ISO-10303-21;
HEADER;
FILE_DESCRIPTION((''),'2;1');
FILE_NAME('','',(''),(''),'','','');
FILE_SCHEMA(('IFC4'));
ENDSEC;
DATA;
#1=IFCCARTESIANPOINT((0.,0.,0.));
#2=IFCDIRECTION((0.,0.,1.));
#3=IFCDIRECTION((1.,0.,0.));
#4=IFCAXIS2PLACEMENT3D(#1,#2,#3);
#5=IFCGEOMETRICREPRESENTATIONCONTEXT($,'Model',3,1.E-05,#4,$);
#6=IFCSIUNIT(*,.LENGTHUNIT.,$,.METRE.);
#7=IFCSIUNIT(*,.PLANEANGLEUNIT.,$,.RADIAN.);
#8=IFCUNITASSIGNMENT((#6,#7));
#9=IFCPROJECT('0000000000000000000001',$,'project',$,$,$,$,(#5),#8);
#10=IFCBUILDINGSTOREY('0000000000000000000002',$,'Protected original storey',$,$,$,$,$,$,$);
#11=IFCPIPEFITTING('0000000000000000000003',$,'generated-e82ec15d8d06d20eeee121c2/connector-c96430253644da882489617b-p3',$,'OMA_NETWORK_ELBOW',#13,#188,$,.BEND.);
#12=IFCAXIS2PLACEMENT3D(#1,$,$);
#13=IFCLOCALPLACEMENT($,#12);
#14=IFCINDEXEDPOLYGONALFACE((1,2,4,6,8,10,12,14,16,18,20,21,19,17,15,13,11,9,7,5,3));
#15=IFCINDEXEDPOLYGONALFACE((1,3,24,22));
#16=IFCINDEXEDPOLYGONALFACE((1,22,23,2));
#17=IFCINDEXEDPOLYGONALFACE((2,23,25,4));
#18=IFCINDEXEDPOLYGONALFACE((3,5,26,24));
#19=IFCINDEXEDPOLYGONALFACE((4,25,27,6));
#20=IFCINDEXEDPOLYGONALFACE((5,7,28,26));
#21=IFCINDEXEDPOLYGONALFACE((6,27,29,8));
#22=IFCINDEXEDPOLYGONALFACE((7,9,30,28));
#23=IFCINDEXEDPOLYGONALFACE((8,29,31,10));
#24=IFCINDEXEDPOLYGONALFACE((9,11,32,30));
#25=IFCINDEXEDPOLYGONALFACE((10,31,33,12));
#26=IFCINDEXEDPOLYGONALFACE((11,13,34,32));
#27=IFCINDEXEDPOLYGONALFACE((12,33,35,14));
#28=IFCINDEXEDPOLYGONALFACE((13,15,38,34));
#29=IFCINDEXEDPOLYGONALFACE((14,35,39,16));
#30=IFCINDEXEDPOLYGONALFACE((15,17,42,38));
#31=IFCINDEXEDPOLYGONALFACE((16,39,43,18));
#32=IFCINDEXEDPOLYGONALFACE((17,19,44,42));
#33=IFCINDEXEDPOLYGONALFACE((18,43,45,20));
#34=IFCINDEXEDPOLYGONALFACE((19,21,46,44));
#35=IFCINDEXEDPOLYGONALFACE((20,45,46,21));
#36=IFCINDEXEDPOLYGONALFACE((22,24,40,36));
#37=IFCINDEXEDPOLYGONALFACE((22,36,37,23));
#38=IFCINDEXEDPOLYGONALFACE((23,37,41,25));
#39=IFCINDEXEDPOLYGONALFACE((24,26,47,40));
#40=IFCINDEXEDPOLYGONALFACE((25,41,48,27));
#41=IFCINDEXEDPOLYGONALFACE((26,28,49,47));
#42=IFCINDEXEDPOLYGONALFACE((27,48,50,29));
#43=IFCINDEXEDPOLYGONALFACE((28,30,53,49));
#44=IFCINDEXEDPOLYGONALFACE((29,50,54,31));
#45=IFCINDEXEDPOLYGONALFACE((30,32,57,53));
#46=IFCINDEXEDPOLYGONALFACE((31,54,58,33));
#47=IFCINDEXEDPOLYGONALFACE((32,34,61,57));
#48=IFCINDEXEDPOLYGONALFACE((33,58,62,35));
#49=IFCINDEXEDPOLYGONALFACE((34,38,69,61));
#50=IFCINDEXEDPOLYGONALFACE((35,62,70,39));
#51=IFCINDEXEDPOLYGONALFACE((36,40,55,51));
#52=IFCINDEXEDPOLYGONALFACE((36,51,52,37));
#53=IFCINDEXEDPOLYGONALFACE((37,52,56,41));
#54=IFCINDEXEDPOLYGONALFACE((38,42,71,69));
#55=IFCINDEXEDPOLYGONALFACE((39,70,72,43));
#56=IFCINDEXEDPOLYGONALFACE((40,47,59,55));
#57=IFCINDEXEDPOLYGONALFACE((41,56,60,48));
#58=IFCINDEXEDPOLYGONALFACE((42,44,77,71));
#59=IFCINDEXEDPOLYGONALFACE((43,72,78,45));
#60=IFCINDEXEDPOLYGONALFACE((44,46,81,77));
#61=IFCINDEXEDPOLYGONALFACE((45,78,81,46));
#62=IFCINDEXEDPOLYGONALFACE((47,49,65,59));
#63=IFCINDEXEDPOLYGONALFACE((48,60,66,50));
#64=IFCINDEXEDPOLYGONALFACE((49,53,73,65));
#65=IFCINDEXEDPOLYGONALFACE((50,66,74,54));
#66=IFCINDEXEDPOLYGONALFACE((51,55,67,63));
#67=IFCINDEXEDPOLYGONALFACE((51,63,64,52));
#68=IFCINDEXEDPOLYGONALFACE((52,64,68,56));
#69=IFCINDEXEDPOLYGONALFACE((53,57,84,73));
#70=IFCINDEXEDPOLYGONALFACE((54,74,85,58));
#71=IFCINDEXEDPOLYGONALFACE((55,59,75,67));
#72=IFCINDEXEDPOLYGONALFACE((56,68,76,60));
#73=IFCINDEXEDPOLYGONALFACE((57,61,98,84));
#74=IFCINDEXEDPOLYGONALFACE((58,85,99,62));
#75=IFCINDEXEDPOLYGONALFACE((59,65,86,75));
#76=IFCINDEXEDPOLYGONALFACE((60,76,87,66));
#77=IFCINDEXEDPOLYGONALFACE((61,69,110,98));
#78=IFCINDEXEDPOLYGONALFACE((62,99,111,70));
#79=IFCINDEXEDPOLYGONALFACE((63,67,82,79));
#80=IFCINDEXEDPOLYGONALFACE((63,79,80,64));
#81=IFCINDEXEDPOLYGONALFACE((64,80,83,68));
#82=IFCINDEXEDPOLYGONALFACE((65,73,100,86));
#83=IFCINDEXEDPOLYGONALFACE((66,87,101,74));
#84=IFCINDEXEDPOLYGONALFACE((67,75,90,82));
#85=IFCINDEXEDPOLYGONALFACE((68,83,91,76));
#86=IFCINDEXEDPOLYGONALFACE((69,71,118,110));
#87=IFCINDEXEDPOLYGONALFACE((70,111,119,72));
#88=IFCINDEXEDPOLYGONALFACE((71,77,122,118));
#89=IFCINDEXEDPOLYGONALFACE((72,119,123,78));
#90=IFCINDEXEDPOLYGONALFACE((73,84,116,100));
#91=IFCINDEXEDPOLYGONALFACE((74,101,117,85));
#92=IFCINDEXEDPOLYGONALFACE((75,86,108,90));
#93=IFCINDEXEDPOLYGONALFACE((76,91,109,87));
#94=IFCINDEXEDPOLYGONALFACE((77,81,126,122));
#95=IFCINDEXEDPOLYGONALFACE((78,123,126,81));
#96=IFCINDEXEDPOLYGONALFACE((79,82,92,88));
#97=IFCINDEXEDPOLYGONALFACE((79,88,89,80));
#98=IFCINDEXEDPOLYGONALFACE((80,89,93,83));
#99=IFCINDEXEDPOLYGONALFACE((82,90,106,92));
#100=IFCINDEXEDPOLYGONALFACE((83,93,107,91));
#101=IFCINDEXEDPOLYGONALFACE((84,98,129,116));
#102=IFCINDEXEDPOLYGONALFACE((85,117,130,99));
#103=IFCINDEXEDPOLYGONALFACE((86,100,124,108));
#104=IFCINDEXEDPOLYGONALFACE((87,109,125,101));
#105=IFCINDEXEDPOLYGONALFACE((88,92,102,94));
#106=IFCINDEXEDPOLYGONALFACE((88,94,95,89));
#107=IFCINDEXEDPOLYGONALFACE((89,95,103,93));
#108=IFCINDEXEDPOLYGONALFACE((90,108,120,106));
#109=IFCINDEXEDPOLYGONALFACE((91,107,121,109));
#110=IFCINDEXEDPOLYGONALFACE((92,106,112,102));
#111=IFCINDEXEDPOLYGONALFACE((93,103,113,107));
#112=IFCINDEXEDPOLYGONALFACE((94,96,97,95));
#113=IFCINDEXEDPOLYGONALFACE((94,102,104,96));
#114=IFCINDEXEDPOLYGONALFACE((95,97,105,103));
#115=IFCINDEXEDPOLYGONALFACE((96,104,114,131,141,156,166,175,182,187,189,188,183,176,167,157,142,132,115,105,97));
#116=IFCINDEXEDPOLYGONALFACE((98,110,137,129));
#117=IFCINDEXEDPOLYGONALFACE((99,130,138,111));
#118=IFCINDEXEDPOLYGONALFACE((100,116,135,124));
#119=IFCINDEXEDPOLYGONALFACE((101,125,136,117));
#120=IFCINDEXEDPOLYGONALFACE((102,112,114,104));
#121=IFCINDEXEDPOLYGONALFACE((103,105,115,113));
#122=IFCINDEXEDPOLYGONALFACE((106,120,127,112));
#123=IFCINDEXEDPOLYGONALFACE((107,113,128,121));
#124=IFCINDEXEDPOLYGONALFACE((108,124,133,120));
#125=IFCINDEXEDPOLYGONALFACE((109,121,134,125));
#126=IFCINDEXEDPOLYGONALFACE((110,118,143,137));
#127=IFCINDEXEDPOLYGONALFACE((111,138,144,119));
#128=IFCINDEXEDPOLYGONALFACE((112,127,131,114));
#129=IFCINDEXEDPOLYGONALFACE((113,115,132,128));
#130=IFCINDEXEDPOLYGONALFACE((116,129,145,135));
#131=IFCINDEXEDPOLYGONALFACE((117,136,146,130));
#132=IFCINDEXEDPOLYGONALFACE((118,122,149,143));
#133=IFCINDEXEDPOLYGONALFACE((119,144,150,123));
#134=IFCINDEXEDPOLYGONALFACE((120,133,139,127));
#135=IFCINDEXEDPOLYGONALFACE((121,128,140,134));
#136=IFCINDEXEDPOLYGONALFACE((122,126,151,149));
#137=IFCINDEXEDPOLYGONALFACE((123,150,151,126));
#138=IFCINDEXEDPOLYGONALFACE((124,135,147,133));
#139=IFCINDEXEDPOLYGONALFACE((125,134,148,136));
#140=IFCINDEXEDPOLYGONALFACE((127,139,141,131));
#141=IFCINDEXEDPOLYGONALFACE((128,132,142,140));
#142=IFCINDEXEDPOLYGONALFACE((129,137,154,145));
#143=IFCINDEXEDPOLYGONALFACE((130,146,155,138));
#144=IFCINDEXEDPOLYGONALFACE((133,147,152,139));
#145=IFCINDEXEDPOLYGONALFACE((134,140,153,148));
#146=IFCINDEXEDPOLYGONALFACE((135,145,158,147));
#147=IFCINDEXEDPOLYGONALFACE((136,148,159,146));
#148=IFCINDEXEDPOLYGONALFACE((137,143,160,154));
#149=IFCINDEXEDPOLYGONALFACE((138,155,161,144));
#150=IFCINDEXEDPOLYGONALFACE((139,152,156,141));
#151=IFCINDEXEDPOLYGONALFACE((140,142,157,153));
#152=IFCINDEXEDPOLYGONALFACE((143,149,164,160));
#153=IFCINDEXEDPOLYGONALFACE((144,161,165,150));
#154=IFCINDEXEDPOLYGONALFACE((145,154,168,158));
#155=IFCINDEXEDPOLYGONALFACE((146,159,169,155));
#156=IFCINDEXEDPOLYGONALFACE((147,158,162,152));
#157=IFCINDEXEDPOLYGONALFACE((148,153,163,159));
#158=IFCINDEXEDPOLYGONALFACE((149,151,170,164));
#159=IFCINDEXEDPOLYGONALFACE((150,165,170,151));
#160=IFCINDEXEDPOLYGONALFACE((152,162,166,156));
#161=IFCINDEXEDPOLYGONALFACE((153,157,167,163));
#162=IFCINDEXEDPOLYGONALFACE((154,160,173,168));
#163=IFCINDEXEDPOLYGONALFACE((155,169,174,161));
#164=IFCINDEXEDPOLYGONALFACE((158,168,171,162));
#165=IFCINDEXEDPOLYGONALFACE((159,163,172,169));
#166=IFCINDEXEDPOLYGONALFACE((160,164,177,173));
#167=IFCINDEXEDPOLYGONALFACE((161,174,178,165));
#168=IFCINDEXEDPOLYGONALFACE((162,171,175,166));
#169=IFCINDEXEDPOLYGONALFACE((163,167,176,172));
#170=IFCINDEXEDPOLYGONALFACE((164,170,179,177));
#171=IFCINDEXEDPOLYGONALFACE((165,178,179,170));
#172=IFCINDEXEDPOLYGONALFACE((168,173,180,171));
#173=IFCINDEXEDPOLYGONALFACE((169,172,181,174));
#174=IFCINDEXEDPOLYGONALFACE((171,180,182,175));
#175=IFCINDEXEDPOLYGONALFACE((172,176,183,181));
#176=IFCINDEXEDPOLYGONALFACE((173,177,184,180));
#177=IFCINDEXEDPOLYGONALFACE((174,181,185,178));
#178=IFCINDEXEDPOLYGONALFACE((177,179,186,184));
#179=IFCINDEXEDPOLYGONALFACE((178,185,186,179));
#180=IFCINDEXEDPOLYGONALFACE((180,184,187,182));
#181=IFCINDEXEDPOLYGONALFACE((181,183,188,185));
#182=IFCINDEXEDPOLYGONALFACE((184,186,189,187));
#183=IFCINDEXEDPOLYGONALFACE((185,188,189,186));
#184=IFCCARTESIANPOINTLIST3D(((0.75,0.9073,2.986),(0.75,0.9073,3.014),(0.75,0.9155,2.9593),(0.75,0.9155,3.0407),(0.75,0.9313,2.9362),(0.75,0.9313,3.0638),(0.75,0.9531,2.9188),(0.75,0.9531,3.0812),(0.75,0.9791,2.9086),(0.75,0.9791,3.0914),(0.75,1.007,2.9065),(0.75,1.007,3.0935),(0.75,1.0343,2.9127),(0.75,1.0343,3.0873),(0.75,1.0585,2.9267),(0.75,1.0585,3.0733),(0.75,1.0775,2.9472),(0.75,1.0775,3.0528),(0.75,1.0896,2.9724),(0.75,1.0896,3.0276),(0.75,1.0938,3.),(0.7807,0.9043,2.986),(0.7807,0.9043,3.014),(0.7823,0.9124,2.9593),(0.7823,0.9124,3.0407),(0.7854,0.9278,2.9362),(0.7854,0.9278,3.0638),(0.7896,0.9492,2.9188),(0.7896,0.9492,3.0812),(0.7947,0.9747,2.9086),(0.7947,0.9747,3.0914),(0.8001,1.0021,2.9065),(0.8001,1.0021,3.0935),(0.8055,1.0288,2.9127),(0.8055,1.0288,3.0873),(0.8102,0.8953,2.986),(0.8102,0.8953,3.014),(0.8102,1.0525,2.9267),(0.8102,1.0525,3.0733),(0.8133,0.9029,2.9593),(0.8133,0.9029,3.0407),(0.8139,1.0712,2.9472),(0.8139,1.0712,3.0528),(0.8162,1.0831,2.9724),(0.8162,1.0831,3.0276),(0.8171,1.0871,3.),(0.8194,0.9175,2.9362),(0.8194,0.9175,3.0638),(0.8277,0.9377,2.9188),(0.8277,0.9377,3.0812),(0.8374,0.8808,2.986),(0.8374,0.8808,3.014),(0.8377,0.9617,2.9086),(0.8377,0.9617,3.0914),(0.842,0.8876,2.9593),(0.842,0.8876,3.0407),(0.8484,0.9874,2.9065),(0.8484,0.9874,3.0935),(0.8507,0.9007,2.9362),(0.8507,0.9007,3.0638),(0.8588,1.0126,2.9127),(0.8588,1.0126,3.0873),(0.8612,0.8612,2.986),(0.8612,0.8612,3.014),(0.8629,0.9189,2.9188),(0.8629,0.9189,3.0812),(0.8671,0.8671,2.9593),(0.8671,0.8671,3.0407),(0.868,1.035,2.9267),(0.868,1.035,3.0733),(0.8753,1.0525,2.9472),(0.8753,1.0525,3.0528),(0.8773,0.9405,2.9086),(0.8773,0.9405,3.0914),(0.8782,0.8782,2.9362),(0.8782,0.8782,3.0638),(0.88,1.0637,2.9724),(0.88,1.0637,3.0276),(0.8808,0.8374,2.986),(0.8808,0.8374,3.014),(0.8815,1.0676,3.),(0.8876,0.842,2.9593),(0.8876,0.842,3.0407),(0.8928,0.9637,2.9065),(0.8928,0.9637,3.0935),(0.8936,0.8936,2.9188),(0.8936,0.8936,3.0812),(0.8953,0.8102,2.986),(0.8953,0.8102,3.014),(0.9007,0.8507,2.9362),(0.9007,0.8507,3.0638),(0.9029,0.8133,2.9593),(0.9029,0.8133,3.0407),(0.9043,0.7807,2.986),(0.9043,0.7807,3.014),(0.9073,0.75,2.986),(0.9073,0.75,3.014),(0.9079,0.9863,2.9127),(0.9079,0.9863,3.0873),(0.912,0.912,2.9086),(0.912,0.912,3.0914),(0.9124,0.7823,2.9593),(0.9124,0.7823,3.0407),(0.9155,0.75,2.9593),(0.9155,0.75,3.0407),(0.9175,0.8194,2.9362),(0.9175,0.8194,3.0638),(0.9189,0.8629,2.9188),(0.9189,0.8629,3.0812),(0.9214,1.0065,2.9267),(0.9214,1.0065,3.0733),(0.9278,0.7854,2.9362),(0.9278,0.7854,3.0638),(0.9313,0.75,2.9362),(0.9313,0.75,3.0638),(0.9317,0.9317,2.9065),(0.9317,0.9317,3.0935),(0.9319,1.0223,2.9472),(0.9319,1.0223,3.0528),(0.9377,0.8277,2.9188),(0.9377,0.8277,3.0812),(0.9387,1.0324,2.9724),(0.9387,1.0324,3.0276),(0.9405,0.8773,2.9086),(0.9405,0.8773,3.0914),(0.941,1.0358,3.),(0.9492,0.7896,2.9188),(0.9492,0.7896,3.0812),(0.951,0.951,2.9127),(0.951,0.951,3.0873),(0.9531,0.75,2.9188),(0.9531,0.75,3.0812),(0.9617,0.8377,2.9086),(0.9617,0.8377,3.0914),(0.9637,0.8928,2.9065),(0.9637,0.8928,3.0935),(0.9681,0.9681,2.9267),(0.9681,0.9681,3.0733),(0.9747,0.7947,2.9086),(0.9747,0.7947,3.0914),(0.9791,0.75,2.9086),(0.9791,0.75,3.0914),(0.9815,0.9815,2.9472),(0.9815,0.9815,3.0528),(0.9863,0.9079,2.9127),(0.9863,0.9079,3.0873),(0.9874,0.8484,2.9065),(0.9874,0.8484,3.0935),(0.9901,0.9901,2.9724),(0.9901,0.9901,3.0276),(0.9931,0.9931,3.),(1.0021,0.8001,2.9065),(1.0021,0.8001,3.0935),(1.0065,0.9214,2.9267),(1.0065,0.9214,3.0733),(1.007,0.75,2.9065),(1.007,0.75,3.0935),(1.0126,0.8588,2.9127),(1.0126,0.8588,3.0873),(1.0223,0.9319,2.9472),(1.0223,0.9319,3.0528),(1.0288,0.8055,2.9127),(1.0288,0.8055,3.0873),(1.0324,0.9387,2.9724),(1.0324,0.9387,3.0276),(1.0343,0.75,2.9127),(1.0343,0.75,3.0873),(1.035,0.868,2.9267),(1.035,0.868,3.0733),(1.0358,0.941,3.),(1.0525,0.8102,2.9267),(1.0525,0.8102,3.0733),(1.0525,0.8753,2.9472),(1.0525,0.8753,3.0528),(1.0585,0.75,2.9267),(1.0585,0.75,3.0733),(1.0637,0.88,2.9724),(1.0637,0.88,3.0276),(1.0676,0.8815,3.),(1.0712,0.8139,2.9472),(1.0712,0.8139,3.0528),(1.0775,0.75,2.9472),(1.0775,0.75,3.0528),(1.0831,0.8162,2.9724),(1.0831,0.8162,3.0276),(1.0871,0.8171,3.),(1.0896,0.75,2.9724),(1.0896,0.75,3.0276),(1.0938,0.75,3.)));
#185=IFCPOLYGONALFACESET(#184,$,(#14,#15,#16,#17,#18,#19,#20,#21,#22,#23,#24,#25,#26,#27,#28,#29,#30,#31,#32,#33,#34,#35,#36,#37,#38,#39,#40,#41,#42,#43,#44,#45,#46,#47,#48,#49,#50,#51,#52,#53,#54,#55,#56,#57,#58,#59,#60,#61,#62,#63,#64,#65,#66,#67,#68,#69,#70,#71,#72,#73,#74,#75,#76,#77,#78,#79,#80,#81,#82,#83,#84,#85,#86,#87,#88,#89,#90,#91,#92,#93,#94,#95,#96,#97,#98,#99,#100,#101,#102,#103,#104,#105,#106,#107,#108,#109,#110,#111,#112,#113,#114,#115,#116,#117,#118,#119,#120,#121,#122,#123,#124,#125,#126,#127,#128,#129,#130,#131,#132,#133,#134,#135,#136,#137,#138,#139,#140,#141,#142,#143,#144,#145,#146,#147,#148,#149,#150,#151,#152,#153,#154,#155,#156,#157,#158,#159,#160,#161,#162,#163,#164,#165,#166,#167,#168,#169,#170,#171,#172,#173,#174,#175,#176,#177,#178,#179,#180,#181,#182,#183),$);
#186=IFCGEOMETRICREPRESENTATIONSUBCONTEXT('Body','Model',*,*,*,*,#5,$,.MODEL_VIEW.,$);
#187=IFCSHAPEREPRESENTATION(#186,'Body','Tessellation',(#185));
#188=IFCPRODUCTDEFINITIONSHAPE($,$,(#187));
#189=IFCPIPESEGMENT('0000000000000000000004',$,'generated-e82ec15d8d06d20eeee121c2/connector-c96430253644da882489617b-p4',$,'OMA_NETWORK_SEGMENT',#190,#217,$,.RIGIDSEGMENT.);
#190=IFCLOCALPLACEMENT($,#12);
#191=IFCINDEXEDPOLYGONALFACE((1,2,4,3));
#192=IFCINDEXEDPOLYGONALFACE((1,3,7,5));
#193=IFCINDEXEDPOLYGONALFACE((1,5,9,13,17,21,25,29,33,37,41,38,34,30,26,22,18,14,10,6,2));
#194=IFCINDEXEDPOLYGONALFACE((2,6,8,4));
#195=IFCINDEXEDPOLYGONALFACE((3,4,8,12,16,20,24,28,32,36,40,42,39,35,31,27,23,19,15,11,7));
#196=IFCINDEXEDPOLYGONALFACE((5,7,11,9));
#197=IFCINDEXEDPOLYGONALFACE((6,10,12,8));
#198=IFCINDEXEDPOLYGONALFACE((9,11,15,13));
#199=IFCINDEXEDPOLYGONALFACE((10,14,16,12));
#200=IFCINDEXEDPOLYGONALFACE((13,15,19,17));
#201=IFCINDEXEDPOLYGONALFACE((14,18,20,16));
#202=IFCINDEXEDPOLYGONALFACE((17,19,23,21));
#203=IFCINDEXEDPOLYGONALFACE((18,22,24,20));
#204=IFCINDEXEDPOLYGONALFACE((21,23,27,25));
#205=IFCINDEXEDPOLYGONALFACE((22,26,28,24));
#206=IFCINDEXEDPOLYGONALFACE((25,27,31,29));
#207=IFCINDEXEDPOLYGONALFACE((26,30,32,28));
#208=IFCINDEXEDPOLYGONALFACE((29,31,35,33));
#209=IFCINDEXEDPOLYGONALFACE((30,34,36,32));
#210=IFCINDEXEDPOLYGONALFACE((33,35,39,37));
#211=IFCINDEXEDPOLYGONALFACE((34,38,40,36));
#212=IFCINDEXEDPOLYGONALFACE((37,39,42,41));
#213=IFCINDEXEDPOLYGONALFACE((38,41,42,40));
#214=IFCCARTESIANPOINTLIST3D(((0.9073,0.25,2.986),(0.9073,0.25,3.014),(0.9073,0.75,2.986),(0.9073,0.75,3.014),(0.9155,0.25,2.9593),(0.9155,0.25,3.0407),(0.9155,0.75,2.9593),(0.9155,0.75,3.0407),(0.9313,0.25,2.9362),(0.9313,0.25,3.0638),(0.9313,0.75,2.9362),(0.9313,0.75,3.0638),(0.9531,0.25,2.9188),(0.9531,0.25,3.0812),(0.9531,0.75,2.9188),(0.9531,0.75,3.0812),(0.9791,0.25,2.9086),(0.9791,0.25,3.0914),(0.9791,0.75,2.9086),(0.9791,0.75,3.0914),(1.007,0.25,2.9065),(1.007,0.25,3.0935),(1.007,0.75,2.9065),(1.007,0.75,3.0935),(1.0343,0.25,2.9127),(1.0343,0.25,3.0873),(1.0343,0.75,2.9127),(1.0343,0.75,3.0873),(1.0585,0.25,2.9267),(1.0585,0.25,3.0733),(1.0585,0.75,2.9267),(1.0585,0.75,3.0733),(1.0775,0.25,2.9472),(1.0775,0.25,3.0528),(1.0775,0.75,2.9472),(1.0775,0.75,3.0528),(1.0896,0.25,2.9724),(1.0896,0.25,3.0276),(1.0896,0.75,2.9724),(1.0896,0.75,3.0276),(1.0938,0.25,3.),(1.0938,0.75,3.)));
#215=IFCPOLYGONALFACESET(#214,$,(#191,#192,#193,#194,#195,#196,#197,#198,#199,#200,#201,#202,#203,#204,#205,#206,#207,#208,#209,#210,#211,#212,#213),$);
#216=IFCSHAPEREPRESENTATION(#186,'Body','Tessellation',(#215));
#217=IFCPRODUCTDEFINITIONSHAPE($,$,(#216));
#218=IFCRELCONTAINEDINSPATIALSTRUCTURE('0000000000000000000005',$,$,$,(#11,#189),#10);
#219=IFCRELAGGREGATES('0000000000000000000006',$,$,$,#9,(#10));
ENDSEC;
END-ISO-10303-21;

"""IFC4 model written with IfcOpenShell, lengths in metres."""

from ifc_helpers import new_model, entity, si_unit, frame, origin_with_axes, origin_2d, place, context, subcontext, project, spatial, circle, extrude, element, save


model = new_model("IFC4")

# Units and contexts
model_context = context("Model", 3, precision=1e-05, world=origin_with_axes())
body_context = subcontext(model_context, "Body", "Model", "MODEL_VIEW")
ifc_project = project(units=[si_unit("LENGTHUNIT", "METRE"), si_unit("PLANEANGLEUNIT", "RADIAN")], contexts=[model_context])

# Storey
storey = spatial("IfcBuildingStorey", under=ifc_project, Name="Protected original storey")

# Pipe fitting
pipe_fitting_1_placement = place(None, origin_with_axes())
element("IfcPipeFitting", 1, at=pipe_fitting_1_placement, inside=storey, Name="generated-e82ec15d8d06d20eeee121c2/connector-c96430253644da882489617b-p3", ObjectType="OMA_NETWORK_ELBOW", PredefinedType="BEND", context=body_context, shape_type="SweptSolid", body=[
    entity("IfcRevolvedAreaSolid", entity("IfcCircleProfileDef", "AREA", None, entity("IfcAxis2Placement2D", entity("IfcCartesianPoint", [0.25, 0.0])), 0.0938), entity("IfcAxis2Placement3D", entity("IfcCartesianPoint", [0.75, 0.75, 3.0]), entity("IfcDirection", [1.0, 0.0, 0.0]), entity("IfcDirection", [0.0, 1.0, 0.0])), entity("IfcAxis1Placement", entity("IfcCartesianPoint", [0.0, 0.0, 0.0]), entity("IfcDirection", [0.0, -1.0, 0.0])), 1.570796),
])

# Pipe segment
pipe_segment_1_placement = place(None, origin_with_axes())
element("IfcPipeSegment", 2, at=pipe_segment_1_placement, inside=storey, Name="generated-e82ec15d8d06d20eeee121c2/connector-c96430253644da882489617b-p4", ObjectType="OMA_NETWORK_SEGMENT", PredefinedType="RIGIDSEGMENT", context=body_context, shape_type="SweptSolid", body=[
    extrude(circle(Radius=0.0938, at=origin_2d()), frame((1.0, 0.75, 3.0), z_axis=(0.0, -1.0, 0.0), x_axis=(1.0, 0.0, 0.0)), (0.0, 0.0, 1.0), 0.5),
])

save(model, "model.ifc")
